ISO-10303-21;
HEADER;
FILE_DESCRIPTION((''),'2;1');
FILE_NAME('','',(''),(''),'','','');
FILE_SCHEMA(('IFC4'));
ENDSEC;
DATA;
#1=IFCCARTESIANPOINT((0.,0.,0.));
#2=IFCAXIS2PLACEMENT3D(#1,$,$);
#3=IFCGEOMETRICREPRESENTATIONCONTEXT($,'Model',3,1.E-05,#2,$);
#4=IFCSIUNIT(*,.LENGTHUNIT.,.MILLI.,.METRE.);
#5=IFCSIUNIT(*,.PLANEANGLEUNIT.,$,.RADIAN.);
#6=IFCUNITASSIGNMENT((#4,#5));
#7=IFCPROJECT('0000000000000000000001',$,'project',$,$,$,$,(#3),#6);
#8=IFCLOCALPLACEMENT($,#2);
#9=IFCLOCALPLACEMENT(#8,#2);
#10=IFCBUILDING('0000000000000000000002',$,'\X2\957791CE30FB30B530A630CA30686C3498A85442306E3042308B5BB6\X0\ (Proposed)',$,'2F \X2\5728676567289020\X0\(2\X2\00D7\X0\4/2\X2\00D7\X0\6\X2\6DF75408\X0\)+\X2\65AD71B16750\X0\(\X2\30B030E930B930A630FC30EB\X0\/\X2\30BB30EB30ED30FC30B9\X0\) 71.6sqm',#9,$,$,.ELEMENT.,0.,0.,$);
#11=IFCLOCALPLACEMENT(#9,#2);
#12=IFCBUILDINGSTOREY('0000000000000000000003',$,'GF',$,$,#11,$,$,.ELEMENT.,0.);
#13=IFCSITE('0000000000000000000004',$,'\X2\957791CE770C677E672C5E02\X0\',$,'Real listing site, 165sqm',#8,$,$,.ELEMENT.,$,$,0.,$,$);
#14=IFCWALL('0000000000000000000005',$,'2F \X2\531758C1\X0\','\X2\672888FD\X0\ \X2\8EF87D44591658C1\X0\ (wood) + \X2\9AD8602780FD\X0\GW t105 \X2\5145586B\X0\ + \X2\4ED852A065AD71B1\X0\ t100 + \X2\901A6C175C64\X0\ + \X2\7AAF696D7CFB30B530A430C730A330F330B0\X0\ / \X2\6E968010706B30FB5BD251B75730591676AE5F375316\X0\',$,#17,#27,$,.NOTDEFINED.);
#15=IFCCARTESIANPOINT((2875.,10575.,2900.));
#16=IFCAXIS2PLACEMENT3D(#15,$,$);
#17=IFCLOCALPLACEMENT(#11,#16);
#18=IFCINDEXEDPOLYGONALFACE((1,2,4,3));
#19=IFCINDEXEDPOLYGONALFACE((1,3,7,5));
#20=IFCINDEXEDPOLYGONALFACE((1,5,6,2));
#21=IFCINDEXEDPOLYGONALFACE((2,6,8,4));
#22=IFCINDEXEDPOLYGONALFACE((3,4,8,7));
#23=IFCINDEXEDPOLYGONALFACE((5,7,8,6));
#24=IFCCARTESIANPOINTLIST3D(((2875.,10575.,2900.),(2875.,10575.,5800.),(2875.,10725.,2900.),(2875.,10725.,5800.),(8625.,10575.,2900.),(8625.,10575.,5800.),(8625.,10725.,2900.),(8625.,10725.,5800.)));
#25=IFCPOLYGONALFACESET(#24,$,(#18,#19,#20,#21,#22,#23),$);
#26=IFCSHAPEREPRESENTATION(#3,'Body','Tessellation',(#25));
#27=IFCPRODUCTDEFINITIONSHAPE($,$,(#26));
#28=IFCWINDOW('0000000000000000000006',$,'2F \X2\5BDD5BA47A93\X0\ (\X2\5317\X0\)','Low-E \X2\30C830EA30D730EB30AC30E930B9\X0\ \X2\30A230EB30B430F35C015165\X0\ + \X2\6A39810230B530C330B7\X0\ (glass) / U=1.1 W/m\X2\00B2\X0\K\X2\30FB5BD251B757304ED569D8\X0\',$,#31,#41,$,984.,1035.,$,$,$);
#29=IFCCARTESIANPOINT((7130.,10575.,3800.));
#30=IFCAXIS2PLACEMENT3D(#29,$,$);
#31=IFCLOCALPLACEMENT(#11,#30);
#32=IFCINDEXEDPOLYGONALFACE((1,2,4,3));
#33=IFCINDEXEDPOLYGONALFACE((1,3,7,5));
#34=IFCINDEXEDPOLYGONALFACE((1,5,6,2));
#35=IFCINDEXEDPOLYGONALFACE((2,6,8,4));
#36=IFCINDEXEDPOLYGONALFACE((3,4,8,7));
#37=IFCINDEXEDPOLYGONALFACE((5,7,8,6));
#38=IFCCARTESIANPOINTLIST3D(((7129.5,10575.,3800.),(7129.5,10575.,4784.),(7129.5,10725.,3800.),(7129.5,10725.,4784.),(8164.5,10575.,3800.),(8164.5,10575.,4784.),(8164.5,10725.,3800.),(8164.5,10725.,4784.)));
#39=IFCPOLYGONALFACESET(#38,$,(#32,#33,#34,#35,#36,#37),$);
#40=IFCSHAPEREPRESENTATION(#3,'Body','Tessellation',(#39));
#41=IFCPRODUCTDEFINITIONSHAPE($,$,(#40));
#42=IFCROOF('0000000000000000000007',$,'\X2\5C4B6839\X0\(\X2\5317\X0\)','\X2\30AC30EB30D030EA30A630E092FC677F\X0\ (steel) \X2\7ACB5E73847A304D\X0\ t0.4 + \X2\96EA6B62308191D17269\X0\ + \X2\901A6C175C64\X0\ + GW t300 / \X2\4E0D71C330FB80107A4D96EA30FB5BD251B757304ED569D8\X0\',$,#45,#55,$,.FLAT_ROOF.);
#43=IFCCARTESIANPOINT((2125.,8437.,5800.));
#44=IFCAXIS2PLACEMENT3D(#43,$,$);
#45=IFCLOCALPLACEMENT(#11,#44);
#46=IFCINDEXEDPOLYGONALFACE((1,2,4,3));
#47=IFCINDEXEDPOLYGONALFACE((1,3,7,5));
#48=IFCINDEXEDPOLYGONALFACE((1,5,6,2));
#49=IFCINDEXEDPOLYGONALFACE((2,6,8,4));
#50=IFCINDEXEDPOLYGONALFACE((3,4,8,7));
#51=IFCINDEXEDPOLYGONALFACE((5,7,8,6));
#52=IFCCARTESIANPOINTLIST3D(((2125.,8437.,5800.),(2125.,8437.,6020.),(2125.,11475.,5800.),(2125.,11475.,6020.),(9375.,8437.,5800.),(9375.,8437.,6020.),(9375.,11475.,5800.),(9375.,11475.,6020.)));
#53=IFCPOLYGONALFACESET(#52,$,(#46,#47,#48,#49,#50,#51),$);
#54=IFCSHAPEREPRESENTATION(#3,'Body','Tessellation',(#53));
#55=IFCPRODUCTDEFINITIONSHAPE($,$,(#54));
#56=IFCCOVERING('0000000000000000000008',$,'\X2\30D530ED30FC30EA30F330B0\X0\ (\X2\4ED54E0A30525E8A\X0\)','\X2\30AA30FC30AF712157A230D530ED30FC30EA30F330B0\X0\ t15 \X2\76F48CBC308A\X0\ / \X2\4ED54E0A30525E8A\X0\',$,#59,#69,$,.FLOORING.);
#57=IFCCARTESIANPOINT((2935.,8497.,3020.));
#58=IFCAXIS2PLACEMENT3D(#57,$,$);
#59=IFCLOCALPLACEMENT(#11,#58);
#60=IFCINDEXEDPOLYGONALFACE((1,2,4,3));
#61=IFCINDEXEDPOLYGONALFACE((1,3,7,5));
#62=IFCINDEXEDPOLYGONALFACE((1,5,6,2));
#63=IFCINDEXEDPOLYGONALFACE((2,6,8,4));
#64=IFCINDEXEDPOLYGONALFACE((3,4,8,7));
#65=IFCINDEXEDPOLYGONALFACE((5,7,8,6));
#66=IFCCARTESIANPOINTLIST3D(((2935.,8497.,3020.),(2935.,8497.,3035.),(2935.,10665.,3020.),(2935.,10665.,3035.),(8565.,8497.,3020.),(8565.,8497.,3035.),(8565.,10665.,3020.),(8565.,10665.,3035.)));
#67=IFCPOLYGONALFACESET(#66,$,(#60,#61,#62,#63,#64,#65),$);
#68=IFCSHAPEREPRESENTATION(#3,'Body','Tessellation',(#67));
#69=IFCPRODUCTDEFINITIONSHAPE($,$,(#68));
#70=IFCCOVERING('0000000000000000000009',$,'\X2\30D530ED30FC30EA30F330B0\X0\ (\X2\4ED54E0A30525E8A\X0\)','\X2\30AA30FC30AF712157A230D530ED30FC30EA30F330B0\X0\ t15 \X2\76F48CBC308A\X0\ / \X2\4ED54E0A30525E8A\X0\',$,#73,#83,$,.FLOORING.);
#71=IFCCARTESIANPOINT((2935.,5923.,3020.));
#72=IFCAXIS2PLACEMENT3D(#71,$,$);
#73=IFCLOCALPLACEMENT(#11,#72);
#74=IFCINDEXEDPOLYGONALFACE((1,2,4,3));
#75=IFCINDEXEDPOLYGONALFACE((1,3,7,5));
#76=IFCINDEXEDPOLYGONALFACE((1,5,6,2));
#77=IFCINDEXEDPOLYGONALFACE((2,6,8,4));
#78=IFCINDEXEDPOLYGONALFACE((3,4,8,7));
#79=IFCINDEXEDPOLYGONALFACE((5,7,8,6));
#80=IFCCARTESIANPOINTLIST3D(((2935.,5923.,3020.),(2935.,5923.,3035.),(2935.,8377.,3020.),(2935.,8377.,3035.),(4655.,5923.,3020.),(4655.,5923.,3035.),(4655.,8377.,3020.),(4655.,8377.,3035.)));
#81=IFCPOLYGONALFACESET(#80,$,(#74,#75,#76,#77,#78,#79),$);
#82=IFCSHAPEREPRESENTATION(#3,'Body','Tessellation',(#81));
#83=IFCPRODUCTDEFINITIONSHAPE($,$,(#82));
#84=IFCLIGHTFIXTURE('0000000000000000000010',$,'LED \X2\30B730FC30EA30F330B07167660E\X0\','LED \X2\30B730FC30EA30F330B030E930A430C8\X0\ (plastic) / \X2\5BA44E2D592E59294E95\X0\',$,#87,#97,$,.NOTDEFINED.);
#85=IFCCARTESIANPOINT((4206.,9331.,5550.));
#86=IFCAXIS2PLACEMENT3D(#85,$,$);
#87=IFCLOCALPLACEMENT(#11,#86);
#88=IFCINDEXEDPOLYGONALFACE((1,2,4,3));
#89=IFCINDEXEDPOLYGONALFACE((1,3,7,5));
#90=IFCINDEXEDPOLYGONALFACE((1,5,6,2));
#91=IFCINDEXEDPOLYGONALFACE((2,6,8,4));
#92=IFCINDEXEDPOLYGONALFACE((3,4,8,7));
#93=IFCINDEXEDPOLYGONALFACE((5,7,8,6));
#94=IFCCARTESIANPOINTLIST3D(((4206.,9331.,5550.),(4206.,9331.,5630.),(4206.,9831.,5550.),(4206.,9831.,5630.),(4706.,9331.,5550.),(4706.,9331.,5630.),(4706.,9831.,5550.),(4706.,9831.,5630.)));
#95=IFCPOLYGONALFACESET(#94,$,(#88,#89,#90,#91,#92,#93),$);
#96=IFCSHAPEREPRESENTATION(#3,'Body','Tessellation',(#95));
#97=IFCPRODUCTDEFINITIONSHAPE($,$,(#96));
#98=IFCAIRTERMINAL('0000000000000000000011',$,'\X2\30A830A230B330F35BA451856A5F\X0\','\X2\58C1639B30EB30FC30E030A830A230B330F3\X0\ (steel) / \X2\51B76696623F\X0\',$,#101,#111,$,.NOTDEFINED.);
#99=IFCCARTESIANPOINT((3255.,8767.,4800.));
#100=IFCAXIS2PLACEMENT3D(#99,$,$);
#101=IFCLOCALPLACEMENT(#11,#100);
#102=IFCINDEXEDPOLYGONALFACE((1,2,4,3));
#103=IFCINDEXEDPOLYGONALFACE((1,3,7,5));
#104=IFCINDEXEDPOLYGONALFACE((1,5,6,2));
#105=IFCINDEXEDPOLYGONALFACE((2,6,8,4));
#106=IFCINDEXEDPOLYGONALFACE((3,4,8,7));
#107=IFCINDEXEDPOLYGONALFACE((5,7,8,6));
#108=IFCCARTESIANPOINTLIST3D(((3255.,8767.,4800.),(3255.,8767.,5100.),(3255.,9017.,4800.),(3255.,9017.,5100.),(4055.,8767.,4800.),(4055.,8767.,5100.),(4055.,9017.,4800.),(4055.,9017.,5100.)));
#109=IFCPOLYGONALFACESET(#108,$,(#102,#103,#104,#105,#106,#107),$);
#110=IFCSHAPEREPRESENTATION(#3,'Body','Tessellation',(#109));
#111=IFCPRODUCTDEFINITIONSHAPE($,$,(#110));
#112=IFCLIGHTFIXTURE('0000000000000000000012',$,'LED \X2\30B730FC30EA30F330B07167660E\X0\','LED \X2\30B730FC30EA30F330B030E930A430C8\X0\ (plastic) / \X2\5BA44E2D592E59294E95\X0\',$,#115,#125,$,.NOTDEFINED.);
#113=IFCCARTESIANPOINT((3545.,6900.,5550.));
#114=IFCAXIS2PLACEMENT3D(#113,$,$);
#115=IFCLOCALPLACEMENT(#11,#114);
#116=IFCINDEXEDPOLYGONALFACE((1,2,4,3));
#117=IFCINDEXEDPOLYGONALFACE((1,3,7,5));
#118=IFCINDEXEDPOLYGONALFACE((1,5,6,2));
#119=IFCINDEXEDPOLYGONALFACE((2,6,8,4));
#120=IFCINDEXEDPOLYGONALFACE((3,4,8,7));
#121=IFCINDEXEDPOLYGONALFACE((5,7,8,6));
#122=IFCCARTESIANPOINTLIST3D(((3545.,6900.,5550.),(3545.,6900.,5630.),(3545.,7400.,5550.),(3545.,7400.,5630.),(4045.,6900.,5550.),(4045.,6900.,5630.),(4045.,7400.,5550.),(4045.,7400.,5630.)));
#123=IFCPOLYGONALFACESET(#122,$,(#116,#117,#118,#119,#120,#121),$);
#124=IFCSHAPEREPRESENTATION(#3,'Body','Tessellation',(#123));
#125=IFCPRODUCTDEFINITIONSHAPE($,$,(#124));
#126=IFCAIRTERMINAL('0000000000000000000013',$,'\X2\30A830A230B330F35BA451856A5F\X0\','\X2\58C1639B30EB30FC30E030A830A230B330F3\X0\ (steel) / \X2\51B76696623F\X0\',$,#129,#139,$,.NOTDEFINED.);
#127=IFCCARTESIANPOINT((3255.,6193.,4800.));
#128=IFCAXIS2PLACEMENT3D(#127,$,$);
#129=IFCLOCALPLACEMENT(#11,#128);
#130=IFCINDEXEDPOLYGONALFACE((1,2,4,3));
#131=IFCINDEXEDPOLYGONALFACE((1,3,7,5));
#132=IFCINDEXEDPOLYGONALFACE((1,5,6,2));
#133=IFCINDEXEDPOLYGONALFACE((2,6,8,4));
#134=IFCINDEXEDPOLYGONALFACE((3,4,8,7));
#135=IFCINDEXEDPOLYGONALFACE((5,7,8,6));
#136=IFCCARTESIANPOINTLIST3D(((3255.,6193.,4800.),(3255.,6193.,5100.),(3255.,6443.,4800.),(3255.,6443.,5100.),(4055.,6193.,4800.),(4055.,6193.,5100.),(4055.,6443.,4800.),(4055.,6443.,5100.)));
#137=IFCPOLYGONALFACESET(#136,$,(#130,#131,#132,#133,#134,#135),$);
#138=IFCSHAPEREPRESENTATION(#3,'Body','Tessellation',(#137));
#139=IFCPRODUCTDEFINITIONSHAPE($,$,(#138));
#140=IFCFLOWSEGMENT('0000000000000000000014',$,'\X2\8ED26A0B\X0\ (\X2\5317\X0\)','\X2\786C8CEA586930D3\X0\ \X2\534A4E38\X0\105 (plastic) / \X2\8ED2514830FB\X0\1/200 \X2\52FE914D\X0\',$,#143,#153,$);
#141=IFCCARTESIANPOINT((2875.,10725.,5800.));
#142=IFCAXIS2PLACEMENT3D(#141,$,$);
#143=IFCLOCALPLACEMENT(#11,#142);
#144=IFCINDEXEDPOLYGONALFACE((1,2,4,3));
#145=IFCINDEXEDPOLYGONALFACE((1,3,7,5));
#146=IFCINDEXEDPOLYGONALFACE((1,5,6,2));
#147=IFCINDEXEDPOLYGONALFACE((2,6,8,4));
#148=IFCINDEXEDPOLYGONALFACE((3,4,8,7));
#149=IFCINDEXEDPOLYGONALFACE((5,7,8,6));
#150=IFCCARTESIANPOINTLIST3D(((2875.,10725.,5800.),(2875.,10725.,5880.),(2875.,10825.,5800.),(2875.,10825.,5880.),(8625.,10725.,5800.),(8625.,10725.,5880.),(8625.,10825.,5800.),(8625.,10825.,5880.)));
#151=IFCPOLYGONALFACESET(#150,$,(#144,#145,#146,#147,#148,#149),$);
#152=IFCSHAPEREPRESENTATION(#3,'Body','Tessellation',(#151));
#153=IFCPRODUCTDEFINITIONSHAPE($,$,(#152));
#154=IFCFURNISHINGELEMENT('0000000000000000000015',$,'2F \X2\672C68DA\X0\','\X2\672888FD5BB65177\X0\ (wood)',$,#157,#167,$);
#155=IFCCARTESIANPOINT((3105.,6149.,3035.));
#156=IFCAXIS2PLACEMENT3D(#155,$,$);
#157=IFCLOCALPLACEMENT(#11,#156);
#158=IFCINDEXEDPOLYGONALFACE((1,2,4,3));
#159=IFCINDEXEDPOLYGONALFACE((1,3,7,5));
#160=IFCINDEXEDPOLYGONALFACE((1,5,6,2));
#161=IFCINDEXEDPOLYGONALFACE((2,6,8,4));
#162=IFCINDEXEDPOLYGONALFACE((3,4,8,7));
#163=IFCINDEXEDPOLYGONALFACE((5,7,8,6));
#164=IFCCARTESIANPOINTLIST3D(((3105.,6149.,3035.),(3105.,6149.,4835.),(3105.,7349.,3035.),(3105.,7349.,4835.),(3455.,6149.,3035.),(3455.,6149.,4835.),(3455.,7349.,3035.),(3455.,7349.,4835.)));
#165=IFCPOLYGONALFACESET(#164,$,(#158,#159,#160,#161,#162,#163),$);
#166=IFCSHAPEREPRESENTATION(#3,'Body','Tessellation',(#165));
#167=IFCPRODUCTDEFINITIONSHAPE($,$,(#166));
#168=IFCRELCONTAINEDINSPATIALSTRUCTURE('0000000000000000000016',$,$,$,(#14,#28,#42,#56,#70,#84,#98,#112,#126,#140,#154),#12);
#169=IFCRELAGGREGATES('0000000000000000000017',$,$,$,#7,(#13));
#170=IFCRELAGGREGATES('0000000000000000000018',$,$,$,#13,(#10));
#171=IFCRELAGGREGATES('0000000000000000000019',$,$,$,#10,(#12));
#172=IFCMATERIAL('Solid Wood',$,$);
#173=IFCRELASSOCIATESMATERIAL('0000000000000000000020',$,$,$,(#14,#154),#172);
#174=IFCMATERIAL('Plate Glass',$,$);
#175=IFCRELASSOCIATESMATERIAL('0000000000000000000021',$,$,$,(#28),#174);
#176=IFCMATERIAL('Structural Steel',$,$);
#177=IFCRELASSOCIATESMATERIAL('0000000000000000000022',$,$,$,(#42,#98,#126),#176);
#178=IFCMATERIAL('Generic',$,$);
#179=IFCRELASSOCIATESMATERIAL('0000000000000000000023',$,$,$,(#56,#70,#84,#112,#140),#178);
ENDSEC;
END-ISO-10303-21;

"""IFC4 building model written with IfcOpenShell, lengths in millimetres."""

from ifc_helpers import new_model, si_unit, frame, frame_2d, origin, place, context, project, spatial, rectangle, extrude, material, element, fill, save


model = new_model("IFC4")

# Units and contexts
model_context = context("Model", 3, precision=1e-05, world=origin())
ifc_project = project(units=[si_unit("LENGTHUNIT", "METRE", prefix="MILLI"), si_unit("PLANEANGLEUNIT", "RADIAN")], contexts=[model_context])

# Site, building, storey
site_placement = place(None, origin())
site = spatial("IfcSite", under=ifc_project, at=site_placement, Name="長野県松本市", ObjectType="Real listing site, 165sqm", CompositionType="ELEMENT", RefElevation=0.0)
building_placement = place(site_placement, origin())
building = spatial("IfcBuilding", under=site, at=building_placement, Name="長野・サウナと水風呂のある家 (Proposed)", ObjectType="2F 在来木造(2×4/2×6混合)+断熱材(グラスウール/セルロース) 71.6sqm", CompositionType="ELEMENT", ElevationOfRefHeight=0.0, ElevationOfTerrain=0.0)
storey_placement = place(building_placement, origin())
storey = spatial("IfcBuildingStorey", under=building, at=storey_placement, Name="GF", CompositionType="ELEMENT", Elevation=0.0)

# Shared definitions
ifc_material_1 = material(Name="Solid Wood")

# Wall, opening, window
wall_placement = place(storey_placement, frame((2875.0, 10575.0, 2900.0)))
wall = element("IfcWall", 1, at=wall_placement, inside=storey, material=ifc_material_1, Name="2F 北壁", Description="木製 軸組外壁 (wood) + 高性能GW t105 充填 + 付加断熱 t100 + 通気層 + 窯業系サイディング / 準耐火・寒冷地外皮強化", PredefinedType="NOTDEFINED", context=model_context, shape_type="SweptSolid", body=[
    extrude(rectangle(XDim=5750.0, YDim=150.0, at=frame_2d((2875.0, 75.0))), frame((2875.0, 10575.0, 2900.0)), (0.0, 0.0, 1.0), 2900.0),
])
opening_placement = place(storey_placement, frame((7130.0, 10575.0, 3800.0)))
opening = element("IfcOpeningElement", 2, at=opening_placement, cuts=wall, PredefinedType="NOTDEFINED", context=model_context, shape_type="SweptSolid", body=[
    extrude(rectangle(XDim=1035.0, YDim=150.0, at=frame_2d((517.0, 75.0))), frame((7130.0, 10575.0, 3800.0)), (0.0, 0.0, 1.0), 984.0),
])
ifc_material_2 = material(Name="Plate Glass")
window_placement = place(storey_placement, frame((7130.0, 10575.0, 3800.0)))
window = element("IfcWindow", 3, at=window_placement, inside=storey, material=ifc_material_2, Name="2F 寝室窓 (北)", Description="Low-E トリプルガラス アルゴン封入 + 樹脂サッシ (glass) / U=1.1 W/m²K・寒冷地仕様", OverallHeight=984.0, OverallWidth=1035.0, context=model_context, shape_type="SweptSolid", body=[
    extrude(rectangle(XDim=1035.0, YDim=150.0, at=frame_2d((517.0, 75.0))), frame((7130.0, 10575.0, 3800.0)), (0.0, 0.0, 1.0), 984.0),
])
fill(opening, window)

# Roof
ifc_material_3 = material(Name="Structural Steel")
for number, where, name in (
    (4, (2125.0, 8437.0, 5800.0), "屋根(北)"),
):
    element("IfcRoof", number, at=place(storey_placement, frame(where)), inside=storey, material=ifc_material_3, Name=name, Description="ガルバリウム鋼板 (steel) 立平葺き t0.4 + 雪止め金物 + 通気層 + GW t300 / 不燃・耐積雪・寒冷地仕様", PredefinedType="FLAT_ROOF", context=model_context, shape_type="SweptSolid", body=[
        extrude(rectangle(XDim=7250.0, YDim=3038.0, at=frame_2d((3625.0, 1519.0))), frame((2125.0, 8437.0, 5800.0)), (0.0, 0.0, 1.0), 220.0),
    ])

# Coverings
ifc_material_4 = material(Name="Generic")
covering_1_placement = place(storey_placement, frame((2935.0, 8497.0, 3020.0)))
element("IfcCovering", 5, at=covering_1_placement, inside=storey, material=ifc_material_4, Name="フローリング (仕上げ床)", Description="オーク無垢フローリング t15 直貼り / 仕上げ床", PredefinedType="FLOORING", context=model_context, shape_type="SweptSolid", body=[
    extrude(rectangle(XDim=5630.0, YDim=2168.0, at=frame_2d((2815.0, 1084.0))), frame((2935.0, 8497.0, 3020.0)), (0.0, 0.0, 1.0), 15.0),
])
covering_2_placement = place(storey_placement, frame((2935.0, 5923.0, 3020.0)))
element("IfcCovering", 6, at=covering_2_placement, inside=storey, material=ifc_material_4, Name="フローリング (仕上げ床)", Description="オーク無垢フローリング t15 直貼り / 仕上げ床", PredefinedType="FLOORING", context=model_context, shape_type="SweptSolid", body=[
    extrude(rectangle(XDim=1720.0, YDim=2454.0, at=frame_2d((860.0, 1227.0))), frame((2935.0, 5923.0, 3020.0)), (0.0, 0.0, 1.0), 15.0),
])

# Light fixture
light_fixture_1_placement = place(storey_placement, frame((4206.0, 9331.0, 5550.0)))
element("IfcLightFixture", 7, at=light_fixture_1_placement, inside=storey, material=ifc_material_4, Name="LED シーリング照明", Description="LED シーリングライト (plastic) / 室中央天井", PredefinedType="NOTDEFINED", context=model_context, shape_type="SweptSolid", body=[
    extrude(rectangle(XDim=500.0, YDim=500.0, at=frame_2d((250.0, 250.0))), frame((4206.0, 9331.0, 5550.0)), (0.0, 0.0, 1.0), 80.0),
])

# Air terminal
air_terminal_1_placement = place(storey_placement, frame((3255.0, 8767.0, 4800.0)))
element("IfcAirTerminal", 8, at=air_terminal_1_placement, inside=storey, material=ifc_material_3, Name="エアコン室内機", Description="壁掛ルームエアコン (steel) / 冷暖房", PredefinedType="NOTDEFINED", context=model_context, shape_type="SweptSolid", body=[
    extrude(rectangle(XDim=800.0, YDim=250.0, at=frame_2d((400.0, 125.0))), frame((3255.0, 8767.0, 4800.0)), (0.0, 0.0, 1.0), 300.0),
])

# Light fixture
light_fixture_2_placement = place(storey_placement, frame((3545.0, 6900.0, 5550.0)))
element("IfcLightFixture", 9, at=light_fixture_2_placement, inside=storey, material=ifc_material_4, Name="LED シーリング照明", Description="LED シーリングライト (plastic) / 室中央天井", PredefinedType="NOTDEFINED", context=model_context, shape_type="SweptSolid", body=[
    extrude(rectangle(XDim=500.0, YDim=500.0, at=frame_2d((250.0, 250.0))), frame((3545.0, 6900.0, 5550.0)), (0.0, 0.0, 1.0), 80.0),
])

# Air terminal
air_terminal_2_placement = place(storey_placement, frame((3255.0, 6193.0, 4800.0)))
element("IfcAirTerminal", 10, at=air_terminal_2_placement, inside=storey, material=ifc_material_3, Name="エアコン室内機", Description="壁掛ルームエアコン (steel) / 冷暖房", PredefinedType="NOTDEFINED", context=model_context, shape_type="SweptSolid", body=[
    extrude(rectangle(XDim=800.0, YDim=250.0, at=frame_2d((400.0, 125.0))), frame((3255.0, 6193.0, 4800.0)), (0.0, 0.0, 1.0), 300.0),
])

# Flow segment
flow_segment_placement = place(storey_placement, frame((2875.0, 10725.0, 5800.0)))
element("IfcFlowSegment", 11, at=flow_segment_placement, inside=storey, material=ifc_material_4, Name="軒樋 (北)", Description="硬質塩ビ 半丸105 (plastic) / 軒先・1/200 勾配", context=model_context, shape_type="SweptSolid", body=[
    extrude(rectangle(XDim=5750.0, YDim=100.0, at=frame_2d((2875.0, 50.0))), frame((2875.0, 10725.0, 5800.0)), (0.0, 0.0, 1.0), 80.0),
])

# Furnishing element
furnishing_placement = place(storey_placement, frame((3105.0, 6149.0, 3035.0)))
element("IfcFurnishingElement", 12, at=furnishing_placement, inside=storey, material=ifc_material_1, Name="2F 本棚", Description="木製家具 (wood)", context=model_context, shape_type="SweptSolid", body=[
    extrude(rectangle(XDim=350.0, YDim=1200.0, at=frame_2d((175.0, 600.0))), frame((3105.0, 6149.0, 3035.0)), (0.0, 0.0, 1.0), 1800.0),
])

save(model, "model.ifc")
